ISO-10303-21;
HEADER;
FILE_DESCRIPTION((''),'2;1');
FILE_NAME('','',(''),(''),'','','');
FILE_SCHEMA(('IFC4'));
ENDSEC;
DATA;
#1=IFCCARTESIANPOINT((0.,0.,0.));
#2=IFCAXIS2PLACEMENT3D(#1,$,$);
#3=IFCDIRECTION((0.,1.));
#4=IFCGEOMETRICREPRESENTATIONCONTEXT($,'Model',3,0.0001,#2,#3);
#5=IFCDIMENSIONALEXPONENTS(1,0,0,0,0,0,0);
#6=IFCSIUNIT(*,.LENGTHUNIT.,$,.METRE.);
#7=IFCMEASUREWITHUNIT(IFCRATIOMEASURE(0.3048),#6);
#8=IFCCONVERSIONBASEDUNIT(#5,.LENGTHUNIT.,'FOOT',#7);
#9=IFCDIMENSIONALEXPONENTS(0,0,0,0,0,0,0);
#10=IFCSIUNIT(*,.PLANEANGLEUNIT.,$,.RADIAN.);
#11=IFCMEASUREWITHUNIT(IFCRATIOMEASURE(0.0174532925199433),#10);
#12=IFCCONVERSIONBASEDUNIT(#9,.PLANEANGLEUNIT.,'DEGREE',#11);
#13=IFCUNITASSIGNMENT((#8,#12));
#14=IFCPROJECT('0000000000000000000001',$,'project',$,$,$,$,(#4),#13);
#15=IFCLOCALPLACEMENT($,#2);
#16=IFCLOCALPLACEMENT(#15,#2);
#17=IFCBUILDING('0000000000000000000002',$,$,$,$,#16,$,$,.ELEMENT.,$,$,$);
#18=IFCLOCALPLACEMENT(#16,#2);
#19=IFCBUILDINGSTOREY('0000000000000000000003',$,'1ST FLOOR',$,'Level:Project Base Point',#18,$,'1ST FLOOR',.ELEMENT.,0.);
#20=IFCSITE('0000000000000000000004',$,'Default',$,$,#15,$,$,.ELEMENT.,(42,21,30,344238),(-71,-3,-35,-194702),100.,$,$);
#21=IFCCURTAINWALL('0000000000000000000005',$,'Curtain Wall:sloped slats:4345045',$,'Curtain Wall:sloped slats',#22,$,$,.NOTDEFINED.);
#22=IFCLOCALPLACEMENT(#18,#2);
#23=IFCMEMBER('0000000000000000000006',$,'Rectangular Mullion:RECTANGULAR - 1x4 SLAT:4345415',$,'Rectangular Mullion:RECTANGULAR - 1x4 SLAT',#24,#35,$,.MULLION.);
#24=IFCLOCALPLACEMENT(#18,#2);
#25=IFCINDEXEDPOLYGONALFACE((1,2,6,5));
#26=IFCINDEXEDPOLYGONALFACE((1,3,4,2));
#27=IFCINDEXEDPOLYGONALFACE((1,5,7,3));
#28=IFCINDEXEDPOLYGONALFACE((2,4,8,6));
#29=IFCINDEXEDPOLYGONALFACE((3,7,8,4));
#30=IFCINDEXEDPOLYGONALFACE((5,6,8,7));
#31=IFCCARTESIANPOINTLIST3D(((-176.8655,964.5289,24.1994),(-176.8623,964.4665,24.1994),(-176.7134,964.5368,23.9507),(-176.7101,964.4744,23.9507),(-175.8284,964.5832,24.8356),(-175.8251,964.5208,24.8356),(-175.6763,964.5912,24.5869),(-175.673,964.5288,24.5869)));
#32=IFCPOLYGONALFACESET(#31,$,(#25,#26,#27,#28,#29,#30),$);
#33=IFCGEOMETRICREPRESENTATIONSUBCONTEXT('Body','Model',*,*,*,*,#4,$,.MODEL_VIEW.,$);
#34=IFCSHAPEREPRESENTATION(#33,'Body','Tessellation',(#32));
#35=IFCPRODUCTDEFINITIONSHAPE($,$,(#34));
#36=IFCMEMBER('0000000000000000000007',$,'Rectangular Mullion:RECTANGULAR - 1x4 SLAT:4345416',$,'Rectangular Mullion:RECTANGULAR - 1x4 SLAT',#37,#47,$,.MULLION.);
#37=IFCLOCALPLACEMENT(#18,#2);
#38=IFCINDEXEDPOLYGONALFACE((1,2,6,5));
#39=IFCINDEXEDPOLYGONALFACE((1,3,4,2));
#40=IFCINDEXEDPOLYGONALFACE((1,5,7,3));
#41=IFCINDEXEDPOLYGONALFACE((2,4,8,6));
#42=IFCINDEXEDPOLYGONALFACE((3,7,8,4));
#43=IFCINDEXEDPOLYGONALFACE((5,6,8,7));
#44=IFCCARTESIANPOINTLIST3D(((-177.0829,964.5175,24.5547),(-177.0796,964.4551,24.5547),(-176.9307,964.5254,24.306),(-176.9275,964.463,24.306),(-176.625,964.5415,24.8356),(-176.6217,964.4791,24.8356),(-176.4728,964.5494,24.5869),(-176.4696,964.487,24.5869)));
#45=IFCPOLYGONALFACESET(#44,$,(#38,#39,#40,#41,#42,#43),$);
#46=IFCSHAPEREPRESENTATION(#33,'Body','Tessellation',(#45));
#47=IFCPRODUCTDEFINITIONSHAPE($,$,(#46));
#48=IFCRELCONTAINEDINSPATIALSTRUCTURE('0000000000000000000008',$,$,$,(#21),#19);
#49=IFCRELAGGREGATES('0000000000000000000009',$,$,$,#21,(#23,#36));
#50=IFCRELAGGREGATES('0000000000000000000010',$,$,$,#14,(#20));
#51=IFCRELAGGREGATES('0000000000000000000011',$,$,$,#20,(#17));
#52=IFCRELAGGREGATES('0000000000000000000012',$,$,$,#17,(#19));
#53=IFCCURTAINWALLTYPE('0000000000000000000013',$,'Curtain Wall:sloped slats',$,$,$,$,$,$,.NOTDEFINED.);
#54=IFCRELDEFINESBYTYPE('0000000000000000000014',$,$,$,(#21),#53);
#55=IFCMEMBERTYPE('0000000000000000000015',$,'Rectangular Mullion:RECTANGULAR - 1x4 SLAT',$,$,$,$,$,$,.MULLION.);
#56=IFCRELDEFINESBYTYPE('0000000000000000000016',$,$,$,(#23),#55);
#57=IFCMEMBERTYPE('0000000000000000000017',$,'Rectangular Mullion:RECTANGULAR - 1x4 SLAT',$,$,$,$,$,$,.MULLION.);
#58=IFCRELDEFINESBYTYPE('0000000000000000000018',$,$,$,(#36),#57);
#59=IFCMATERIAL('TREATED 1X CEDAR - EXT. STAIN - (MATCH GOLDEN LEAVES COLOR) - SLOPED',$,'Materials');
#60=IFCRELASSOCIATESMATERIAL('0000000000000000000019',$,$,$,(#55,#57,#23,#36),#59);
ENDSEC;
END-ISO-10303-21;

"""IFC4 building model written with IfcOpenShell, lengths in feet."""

from ifc_helpers import new_model, entity, si_unit, converted_unit, direction, frame, frame_2d, origin, origin_2d_with_axis, place, context, subcontext, project, spatial, rectangle, extrude, source, transform, mapped, material, material_profile, profile_set, profile_usage, type_object, type_shapes, element, aggregate, save


model = new_model("IFC4")

# Units and contexts
model_context = context("Model", 3, precision=0.0001, world=origin(), true_north=direction((0.0, 1.0)))
body_context = subcontext(model_context, "Body", "Model", "MODEL_VIEW")
ifc_project = project(units=[converted_unit("LENGTHUNIT", "FOOT", entity("IfcRatioMeasure", 0.3048), si_unit("LENGTHUNIT", "METRE"), dimensions=[1, 0, 0, 0, 0, 0, 0]), converted_unit("PLANEANGLEUNIT", "DEGREE", entity("IfcRatioMeasure", 0.0174532925199433), si_unit("PLANEANGLEUNIT", "RADIAN"), dimensions=[0, 0, 0, 0, 0, 0, 0])], contexts=[model_context])

# Site, building, storey
site_placement = place(None, origin())
site = spatial("IfcSite", under=ifc_project, at=site_placement, Name="Default", CompositionType="ELEMENT", RefLatitude=(42, 21, 30, 344238), RefLongitude=(-71, -3, -35, -194702), RefElevation=100.0)
building_placement = place(site_placement, origin())
building = spatial("IfcBuilding", under=site, at=building_placement, CompositionType="ELEMENT")
storey_placement = place(building_placement, origin())
storey = spatial("IfcBuildingStorey", under=building, at=storey_placement, Name="1ST FLOOR", ObjectType="Level:Project Base Point", LongName="1ST FLOOR", CompositionType="ELEMENT", Elevation=0.0)

# Curtain wall, members
curtain_wall_type_1 = type_object("IfcCurtainWallType", Name="Curtain Wall:sloped slats", PredefinedType="NOTDEFINED")
curtain_wall_1_placement = place(storey_placement, origin())
curtain_wall_1 = element("IfcCurtainWall", 1, at=curtain_wall_1_placement, inside=storey, type_object=curtain_wall_type_1, Name="Curtain Wall:sloped slats:4345045", ObjectType="Curtain Wall:sloped slats", PredefinedType="NOTDEFINED")
ifc_material_1 = material(Name="TREATED 1X CEDAR - EXT. STAIN - (MATCH GOLDEN LEAVES COLOR) - SLOPED", Category="Materials")
ifc_material_profile_1 = material_profile(ifc_material_1, rectangle(XDim=0.0625, YDim=0.2917, at=frame_2d((0.0, 0.0), x_axis=(1.0, 0.0))), Name="RECTANGULAR - 1x4 SLAT")
ifc_profile_set_1 = profile_set([ifc_material_profile_1], Name="RECTANGULAR - 1x4 SLAT")
ifc_profile_usage_1 = profile_usage(ifc_profile_set_1)
member_type_1 = type_object("IfcMemberType", Name="Rectangular Mullion:RECTANGULAR - 1x4 SLAT", PredefinedType="MULLION", material=ifc_profile_set_1)
shared_shape_1 = source(origin(), body_context, "Body", "SweptSolid", [
    extrude(rectangle(XDim=0.0625, YDim=0.2917, at=origin_2d_with_axis()), frame((0.0, 0.0, -1.2179), z_axis=(0.0, 0.0, 1.0), x_axis=(0.0, -1.0, 0.0)), (0.0, 0.0, 1.0), 1.2179),
])
type_shapes(member_type_1, [shared_shape_1])
member_1_placement = place(storey_placement, frame((-176.7878, 964.5016, 24.0751), z_axis=(-0.851559, -0.044628, -0.522356), x_axis=(-0.52164, -0.027338, 0.852727)))
member_1 = element("IfcMember", 2, at=member_1_placement, type_object=member_type_1, material=ifc_profile_usage_1, Name="Rectangular Mullion:RECTANGULAR - 1x4 SLAT:4345415", ObjectType="Rectangular Mullion:RECTANGULAR - 1x4 SLAT", PredefinedType="MULLION", context=body_context, shape_type="MappedRepresentation", body=[
    mapped(shared_shape_1, transform((0.0, 0.0, 0.0), scale=1.0)),
])
ifc_profile_usage_2 = profile_usage(ifc_profile_set_1)
member_type_2 = type_object("IfcMemberType", Name="Rectangular Mullion:RECTANGULAR - 1x4 SLAT", PredefinedType="MULLION", material=ifc_profile_set_1)
shared_shape_2 = source(origin(), body_context, "Body", "SweptSolid", [
    extrude(rectangle(XDim=0.0625, YDim=0.2917, at=frame_2d((0.0, 0.0), x_axis=(1.0, 0.0))), frame((0.0, 0.0, -0.5377), z_axis=(0.0, 0.0, 1.0), x_axis=(0.0, -1.0, 0.0)), (0.0, 0.0, 1.0), 0.5377),
])
type_shapes(member_type_2, [shared_shape_2])
member_2_placement = place(storey_placement, frame((-177.0052, 964.4903, 24.4304), z_axis=(-0.851559, -0.044628, -0.522356), x_axis=(-0.52164, -0.027338, 0.852727)))
member_2 = element("IfcMember", 3, at=member_2_placement, type_object=member_type_2, material=ifc_profile_usage_2, Name="Rectangular Mullion:RECTANGULAR - 1x4 SLAT:4345416", ObjectType="Rectangular Mullion:RECTANGULAR - 1x4 SLAT", PredefinedType="MULLION", context=body_context, shape_type="MappedRepresentation", body=[
    mapped(shared_shape_2, transform((0.0, 0.0, 0.0), scale=1.0)),
])
aggregate(curtain_wall_1, [member_1, member_2])

save(model, "model.ifc")
